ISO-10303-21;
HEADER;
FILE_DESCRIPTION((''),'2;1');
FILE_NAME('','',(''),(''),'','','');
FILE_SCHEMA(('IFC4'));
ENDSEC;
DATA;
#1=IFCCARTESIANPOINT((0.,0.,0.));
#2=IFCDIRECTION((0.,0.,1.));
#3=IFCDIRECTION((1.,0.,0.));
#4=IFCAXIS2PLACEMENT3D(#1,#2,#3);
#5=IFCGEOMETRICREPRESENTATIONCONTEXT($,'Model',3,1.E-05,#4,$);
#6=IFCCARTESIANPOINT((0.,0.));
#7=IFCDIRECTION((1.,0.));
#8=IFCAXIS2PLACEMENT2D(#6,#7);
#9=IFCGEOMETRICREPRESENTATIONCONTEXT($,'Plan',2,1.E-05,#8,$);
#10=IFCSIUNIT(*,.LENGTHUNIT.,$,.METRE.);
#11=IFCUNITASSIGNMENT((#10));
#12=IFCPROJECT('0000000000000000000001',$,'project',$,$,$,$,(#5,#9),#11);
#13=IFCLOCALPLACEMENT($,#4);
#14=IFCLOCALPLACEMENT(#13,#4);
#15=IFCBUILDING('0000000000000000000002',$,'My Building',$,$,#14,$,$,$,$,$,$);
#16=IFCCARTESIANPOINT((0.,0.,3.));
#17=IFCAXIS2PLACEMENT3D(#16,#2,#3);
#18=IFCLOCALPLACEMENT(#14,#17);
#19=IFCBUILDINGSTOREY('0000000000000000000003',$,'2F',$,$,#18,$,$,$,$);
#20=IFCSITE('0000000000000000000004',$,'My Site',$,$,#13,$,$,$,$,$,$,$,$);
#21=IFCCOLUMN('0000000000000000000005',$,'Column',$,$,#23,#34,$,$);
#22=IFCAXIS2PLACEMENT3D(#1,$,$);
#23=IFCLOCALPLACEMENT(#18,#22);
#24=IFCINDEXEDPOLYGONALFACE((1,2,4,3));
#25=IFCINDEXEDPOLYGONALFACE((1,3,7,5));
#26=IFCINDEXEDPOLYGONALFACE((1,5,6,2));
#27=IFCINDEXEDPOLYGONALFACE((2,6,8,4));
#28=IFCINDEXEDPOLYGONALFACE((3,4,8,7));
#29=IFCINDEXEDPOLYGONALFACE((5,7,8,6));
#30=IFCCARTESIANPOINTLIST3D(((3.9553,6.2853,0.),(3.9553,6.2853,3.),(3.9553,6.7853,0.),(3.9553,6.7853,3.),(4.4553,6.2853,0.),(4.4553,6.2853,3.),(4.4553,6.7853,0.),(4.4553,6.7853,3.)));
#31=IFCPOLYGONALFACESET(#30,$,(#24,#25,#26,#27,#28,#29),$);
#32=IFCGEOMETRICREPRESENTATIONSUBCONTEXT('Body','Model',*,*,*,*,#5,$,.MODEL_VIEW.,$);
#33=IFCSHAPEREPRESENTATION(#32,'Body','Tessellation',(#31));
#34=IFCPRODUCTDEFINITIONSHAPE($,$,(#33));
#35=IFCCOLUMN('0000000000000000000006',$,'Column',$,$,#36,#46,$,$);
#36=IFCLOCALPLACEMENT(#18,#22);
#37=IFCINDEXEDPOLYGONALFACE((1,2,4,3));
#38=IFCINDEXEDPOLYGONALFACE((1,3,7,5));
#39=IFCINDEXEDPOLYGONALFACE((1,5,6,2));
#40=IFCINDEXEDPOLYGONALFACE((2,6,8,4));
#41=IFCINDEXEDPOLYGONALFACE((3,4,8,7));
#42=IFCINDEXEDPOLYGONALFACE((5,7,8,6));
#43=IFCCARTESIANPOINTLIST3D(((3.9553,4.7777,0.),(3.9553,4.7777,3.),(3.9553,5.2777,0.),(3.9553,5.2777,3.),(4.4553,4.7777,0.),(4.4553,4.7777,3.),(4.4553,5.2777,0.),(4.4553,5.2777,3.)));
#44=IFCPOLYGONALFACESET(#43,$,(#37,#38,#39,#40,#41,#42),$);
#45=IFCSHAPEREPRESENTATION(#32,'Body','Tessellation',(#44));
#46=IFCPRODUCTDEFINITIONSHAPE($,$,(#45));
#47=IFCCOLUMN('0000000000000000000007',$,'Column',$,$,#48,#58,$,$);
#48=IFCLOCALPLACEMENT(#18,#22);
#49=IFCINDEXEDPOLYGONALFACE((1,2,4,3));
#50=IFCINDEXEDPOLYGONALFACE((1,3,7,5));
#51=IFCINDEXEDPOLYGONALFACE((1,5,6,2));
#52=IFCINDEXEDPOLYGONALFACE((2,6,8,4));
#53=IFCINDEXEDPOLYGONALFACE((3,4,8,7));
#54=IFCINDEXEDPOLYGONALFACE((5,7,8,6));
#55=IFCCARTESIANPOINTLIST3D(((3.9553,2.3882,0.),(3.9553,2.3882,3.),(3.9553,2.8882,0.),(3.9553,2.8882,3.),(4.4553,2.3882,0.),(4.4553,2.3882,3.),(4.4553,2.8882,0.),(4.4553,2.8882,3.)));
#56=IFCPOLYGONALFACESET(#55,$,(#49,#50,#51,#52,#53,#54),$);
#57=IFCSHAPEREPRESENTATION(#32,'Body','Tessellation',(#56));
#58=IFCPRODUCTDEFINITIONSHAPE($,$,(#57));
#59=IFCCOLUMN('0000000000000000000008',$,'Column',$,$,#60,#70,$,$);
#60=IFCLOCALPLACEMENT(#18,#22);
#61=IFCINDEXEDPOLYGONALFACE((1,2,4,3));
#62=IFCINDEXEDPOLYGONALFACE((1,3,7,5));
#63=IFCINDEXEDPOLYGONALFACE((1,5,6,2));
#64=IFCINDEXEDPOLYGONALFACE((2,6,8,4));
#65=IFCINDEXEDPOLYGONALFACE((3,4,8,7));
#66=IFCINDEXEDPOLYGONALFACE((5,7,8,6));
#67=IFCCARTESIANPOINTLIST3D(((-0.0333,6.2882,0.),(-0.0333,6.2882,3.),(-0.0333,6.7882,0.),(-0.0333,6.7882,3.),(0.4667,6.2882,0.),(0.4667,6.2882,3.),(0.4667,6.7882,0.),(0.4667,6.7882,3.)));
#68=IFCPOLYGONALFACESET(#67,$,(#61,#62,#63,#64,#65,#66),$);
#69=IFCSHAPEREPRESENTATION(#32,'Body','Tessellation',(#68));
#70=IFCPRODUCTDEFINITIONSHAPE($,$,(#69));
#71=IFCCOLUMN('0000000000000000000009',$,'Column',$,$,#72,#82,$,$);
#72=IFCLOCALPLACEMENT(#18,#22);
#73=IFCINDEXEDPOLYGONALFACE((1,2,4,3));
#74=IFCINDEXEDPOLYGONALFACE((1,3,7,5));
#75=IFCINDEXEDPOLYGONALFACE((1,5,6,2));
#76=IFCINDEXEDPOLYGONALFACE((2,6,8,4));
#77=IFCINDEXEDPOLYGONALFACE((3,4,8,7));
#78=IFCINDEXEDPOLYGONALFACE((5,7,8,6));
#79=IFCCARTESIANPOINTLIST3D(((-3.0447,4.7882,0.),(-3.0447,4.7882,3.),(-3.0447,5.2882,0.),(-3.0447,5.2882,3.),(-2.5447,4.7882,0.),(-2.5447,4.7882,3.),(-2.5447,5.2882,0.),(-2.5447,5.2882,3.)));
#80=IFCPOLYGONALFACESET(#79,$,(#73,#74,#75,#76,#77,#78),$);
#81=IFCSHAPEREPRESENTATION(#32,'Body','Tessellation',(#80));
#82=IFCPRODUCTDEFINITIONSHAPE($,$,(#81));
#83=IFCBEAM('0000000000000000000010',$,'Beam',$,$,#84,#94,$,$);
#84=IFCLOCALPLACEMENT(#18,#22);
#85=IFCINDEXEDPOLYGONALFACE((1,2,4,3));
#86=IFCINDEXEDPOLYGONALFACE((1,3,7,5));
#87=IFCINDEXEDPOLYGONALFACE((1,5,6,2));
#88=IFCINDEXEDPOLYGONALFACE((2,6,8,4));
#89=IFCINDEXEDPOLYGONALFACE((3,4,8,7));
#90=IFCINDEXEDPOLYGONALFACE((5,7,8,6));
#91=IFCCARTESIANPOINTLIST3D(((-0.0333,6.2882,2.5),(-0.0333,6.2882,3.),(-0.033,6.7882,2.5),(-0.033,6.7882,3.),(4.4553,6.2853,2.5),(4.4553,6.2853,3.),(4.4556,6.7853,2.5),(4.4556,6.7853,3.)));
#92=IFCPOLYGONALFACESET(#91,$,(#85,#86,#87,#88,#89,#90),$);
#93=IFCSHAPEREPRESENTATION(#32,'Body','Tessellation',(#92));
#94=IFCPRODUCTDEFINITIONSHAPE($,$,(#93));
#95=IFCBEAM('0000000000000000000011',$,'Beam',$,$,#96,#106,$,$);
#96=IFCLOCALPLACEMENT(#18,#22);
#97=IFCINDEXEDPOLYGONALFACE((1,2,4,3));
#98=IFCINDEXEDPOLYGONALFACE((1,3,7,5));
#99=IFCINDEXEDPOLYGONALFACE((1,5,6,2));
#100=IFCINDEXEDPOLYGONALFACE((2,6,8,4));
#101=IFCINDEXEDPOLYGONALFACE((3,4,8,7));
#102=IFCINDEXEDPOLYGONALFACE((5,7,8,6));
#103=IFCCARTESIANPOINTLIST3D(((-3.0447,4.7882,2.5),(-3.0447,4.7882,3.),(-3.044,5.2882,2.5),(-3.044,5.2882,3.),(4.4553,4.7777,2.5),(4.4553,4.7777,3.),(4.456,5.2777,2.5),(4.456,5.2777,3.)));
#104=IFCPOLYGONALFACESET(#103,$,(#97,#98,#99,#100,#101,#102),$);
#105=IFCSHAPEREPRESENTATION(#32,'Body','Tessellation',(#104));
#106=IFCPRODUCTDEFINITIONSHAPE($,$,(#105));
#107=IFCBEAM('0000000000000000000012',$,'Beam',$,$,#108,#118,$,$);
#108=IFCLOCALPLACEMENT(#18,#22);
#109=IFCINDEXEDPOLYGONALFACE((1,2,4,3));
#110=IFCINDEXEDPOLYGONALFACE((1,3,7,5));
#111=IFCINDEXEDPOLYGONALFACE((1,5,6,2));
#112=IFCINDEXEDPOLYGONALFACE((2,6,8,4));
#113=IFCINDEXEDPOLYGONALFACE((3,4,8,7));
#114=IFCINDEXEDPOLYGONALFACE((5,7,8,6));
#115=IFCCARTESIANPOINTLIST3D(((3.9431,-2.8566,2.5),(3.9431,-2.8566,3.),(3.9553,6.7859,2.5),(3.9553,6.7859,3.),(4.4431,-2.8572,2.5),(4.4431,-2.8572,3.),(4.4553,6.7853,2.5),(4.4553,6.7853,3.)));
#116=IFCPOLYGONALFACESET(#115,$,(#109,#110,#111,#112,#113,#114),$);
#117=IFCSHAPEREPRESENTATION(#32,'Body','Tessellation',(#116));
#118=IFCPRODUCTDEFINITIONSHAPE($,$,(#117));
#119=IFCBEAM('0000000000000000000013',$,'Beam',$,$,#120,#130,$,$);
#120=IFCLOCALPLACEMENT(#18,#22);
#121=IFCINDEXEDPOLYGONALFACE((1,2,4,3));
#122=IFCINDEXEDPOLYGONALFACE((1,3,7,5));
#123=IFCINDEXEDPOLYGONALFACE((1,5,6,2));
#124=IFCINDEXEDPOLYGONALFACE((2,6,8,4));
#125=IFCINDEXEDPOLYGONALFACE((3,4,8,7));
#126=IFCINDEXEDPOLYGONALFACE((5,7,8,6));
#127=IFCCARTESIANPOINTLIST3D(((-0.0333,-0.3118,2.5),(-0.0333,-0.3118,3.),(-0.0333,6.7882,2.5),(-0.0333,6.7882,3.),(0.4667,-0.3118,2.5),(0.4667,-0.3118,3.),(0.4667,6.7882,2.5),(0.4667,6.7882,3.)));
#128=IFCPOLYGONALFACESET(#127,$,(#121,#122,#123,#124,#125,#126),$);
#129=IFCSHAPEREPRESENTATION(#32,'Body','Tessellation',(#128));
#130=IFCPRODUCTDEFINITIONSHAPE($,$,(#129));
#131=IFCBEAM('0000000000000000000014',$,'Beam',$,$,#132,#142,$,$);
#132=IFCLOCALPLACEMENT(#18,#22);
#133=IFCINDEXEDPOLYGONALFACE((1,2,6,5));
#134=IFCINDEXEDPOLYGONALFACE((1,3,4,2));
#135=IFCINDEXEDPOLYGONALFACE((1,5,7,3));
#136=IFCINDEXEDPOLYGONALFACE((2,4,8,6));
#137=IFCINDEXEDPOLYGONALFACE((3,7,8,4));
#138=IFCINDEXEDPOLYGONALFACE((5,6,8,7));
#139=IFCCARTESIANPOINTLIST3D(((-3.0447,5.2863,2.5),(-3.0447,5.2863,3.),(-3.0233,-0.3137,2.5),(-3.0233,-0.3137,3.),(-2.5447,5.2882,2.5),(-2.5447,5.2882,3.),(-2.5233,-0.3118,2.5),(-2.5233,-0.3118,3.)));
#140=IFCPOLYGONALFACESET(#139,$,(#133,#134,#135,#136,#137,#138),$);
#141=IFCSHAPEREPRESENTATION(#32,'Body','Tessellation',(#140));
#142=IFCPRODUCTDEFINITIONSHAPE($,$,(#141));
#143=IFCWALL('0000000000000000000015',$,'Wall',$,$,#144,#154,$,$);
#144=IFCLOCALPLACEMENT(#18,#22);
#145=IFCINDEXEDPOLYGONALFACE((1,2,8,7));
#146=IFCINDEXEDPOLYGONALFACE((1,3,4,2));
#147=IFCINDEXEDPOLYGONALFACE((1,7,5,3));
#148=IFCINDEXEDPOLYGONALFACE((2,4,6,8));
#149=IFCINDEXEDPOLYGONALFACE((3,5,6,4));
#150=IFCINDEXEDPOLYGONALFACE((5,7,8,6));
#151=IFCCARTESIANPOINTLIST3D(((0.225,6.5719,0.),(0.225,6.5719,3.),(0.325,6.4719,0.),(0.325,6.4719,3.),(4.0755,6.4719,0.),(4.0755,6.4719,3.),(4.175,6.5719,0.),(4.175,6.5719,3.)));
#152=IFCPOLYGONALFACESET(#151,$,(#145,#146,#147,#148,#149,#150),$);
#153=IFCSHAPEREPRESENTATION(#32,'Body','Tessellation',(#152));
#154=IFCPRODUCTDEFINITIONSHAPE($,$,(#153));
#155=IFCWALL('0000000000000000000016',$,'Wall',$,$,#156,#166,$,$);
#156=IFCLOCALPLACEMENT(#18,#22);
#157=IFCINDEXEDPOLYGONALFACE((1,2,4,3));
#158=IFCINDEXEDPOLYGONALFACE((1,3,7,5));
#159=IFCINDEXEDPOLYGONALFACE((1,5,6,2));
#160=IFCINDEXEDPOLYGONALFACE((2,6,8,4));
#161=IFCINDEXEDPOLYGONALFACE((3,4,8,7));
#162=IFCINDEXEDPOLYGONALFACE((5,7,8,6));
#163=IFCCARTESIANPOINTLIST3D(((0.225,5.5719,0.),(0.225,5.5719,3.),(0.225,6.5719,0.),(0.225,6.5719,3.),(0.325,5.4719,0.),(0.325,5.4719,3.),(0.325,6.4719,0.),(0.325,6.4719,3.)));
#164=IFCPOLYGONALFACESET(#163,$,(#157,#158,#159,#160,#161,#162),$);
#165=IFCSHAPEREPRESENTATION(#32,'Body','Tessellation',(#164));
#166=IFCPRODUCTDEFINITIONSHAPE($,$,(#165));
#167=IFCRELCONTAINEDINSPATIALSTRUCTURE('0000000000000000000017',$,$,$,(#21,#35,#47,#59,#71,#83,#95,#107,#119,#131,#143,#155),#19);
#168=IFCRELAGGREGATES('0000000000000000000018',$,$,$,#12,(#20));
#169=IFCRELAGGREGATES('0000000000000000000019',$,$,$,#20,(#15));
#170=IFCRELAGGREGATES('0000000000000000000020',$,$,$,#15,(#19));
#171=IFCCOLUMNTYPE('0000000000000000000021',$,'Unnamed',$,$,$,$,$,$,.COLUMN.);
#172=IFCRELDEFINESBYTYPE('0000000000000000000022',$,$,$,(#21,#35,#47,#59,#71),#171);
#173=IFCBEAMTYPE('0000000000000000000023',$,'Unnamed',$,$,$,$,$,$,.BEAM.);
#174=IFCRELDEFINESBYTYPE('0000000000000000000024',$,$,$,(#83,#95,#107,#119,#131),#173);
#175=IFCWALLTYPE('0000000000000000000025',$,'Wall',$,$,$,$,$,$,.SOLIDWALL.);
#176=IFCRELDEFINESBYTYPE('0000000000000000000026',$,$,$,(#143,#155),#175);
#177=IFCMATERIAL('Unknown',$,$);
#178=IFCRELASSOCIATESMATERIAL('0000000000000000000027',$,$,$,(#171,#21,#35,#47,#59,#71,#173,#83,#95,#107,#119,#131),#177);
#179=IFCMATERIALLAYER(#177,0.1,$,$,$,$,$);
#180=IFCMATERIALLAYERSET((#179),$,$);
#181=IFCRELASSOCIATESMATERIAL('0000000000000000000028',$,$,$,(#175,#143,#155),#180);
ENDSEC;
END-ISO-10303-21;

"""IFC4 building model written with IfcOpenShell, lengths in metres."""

from ifc_helpers import new_model, si_unit, frame, origin_with_axes, origin_2d_with_axis, place, context, subcontext, project, spatial, line, indexed_curve, rectangle, outline, extrude, material, layer, layer_set, layer_usage, material_profile, profile_set, profile_usage, type_object, element, save


model = new_model("IFC4")

# Units and contexts
model_context = context("Model", 3, precision=1e-05, world=origin_with_axes())
plan_context = context("Plan", 2, precision=1e-05, world=origin_2d_with_axis())
body_context_1 = subcontext(model_context, "Body", "Model", "MODEL_VIEW")
ifc_project = project(units=[si_unit("LENGTHUNIT", "METRE")], contexts=[model_context, plan_context])

# Site, building, storey
site_placement = place(None, origin_with_axes())
site = spatial("IfcSite", under=ifc_project, at=site_placement, Name="My Site")
building_placement = place(site_placement, origin_with_axes())
building = spatial("IfcBuilding", under=site, at=building_placement, Name="My Building")
storey_placement = place(building_placement, frame((0.0, 0.0, 3.0), z_axis=(0.0, 0.0, 1.0), x_axis=(1.0, 0.0, 0.0)))
storey = spatial("IfcBuildingStorey", under=building, at=storey_placement, Name="2F")

# Columns
ifc_material = material(Name="Unknown")
ifc_material_profile_1 = material_profile(ifc_material, rectangle(XDim=0.5, YDim=0.5))
ifc_profile_set_1 = profile_set([ifc_material_profile_1])
ifc_profile_usage_1 = profile_usage(ifc_profile_set_1, cardinal=5)
column_type = type_object("IfcColumnType", Name="Unnamed", PredefinedType="COLUMN", material=ifc_profile_set_1)
column_1_placement = place(storey_placement, frame((4.2053, 6.5353, 0.0), z_axis=(0.0, 0.0, 1.0), x_axis=(1.0, 0.0, 0.0)))
element("IfcColumn", 1, at=column_1_placement, inside=storey, type_object=column_type, material=ifc_profile_usage_1, Name="Column", context=body_context_1, shape_type="SweptSolid", body=[
    extrude(rectangle(XDim=0.5, YDim=0.5), origin_with_axes(), (0.0, 0.0, 1.0), 3.0),
])
ifc_profile_usage_2 = profile_usage(ifc_profile_set_1, cardinal=5)
column_2_placement = place(storey_placement, frame((4.2053, 5.0277, 0.0), z_axis=(0.0, 0.0, 1.0), x_axis=(1.0, 0.0, 0.0)))
element("IfcColumn", 2, at=column_2_placement, inside=storey, type_object=column_type, material=ifc_profile_usage_2, Name="Column", context=body_context_1, shape_type="SweptSolid", body=[
    extrude(rectangle(XDim=0.5, YDim=0.5), origin_with_axes(), (0.0, 0.0, 1.0), 3.0),
])
ifc_profile_usage_3 = profile_usage(ifc_profile_set_1, cardinal=5)
column_3_placement = place(storey_placement, frame((4.2053, 2.6382, 0.0), z_axis=(0.0, 0.0, 1.0), x_axis=(1.0, 0.0, 0.0)))
element("IfcColumn", 3, at=column_3_placement, inside=storey, type_object=column_type, material=ifc_profile_usage_3, Name="Column", context=body_context_1, shape_type="SweptSolid", body=[
    extrude(rectangle(XDim=0.5, YDim=0.5), origin_with_axes(), (0.0, 0.0, 1.0), 3.0),
])
ifc_profile_usage_4 = profile_usage(ifc_profile_set_1, cardinal=5)
column_4_placement = place(storey_placement, frame((0.2167, 6.5382, 0.0), z_axis=(0.0, 0.0, 1.0), x_axis=(1.0, 0.0, 0.0)))
element("IfcColumn", 4, at=column_4_placement, inside=storey, type_object=column_type, material=ifc_profile_usage_4, Name="Column", context=body_context_1, shape_type="SweptSolid", body=[
    extrude(rectangle(XDim=0.5, YDim=0.5), origin_with_axes(), (0.0, 0.0, 1.0), 3.0),
])
ifc_profile_usage_5 = profile_usage(ifc_profile_set_1, cardinal=5)
column_5_placement = place(storey_placement, frame((-2.7947, 5.0382, 0.0), z_axis=(0.0, 0.0, 1.0), x_axis=(1.0, 0.0, 0.0)))
element("IfcColumn", 5, at=column_5_placement, inside=storey, type_object=column_type, material=ifc_profile_usage_5, Name="Column", context=body_context_1, shape_type="SweptSolid", body=[
    extrude(rectangle(XDim=0.5, YDim=0.5), origin_with_axes(), (0.0, 0.0, 1.0), 3.0),
])

# Beams
ifc_material_profile_2 = material_profile(ifc_material, rectangle(XDim=0.5, YDim=0.5))
ifc_profile_set_2 = profile_set([ifc_material_profile_2])
ifc_profile_usage_6 = profile_usage(ifc_profile_set_2, cardinal=7)
beam_type = type_object("IfcBeamType", Name="Unnamed", PredefinedType="BEAM", material=ifc_profile_set_2)
beam_1_placement = place(storey_placement, frame((4.4553, 6.2853, 3.0), z_axis=(-1.0, 0.000651, 0.0), x_axis=(-0.000651, -1.0, 0.0)))
element("IfcBeam", 6, at=beam_1_placement, inside=storey, type_object=beam_type, material=ifc_profile_usage_6, Name="Beam", context=body_context_1, shape_type="SweptSolid", body=[
    extrude(rectangle(XDim=0.5, YDim=0.5), frame((-0.25, -0.25, 0.0), z_axis=(0.0, 0.0, 1.0), x_axis=(1.0, 0.0, 0.0)), (0.0, 0.0, 1.0), 4.4886),
])
ifc_profile_usage_7 = profile_usage(ifc_profile_set_2, cardinal=7)
beam_2_placement = place(storey_placement, frame((4.4553, 4.7777, 3.0), z_axis=(-0.999999, 0.001406, 0.0), x_axis=(-0.001406, -0.999999, 0.0)))
element("IfcBeam", 7, at=beam_2_placement, inside=storey, type_object=beam_type, material=ifc_profile_usage_7, Name="Beam", context=body_context_1, shape_type="SweptSolid", body=[
    extrude(rectangle(XDim=0.5, YDim=0.5), frame((-0.25, -0.25, 0.0), z_axis=(0.0, 0.0, 1.0), x_axis=(1.0, 0.0, 0.0)), (0.0, 0.0, 1.0), 7.5),
])
ifc_profile_usage_8 = profile_usage(ifc_profile_set_2, cardinal=7)
beam_3_placement = place(storey_placement, frame((4.4553, 6.7853, 3.0), z_axis=(-0.001263, -0.999999, 0.0), x_axis=(0.999999, -0.001263, 0.0)))
element("IfcBeam", 8, at=beam_3_placement, inside=storey, type_object=beam_type, material=ifc_profile_usage_8, Name="Beam", context=body_context_1, shape_type="SweptSolid", body=[
    extrude(rectangle(XDim=0.5, YDim=0.5), frame((-0.25, -0.25, 0.0), z_axis=(0.0, 0.0, 1.0), x_axis=(1.0, 0.0, 0.0)), (0.0, 0.0, 1.0), 9.6425),
])
ifc_profile_usage_9 = profile_usage(ifc_profile_set_2, cardinal=7)
beam_4_placement = place(storey_placement, frame((0.4667, 6.7882, 3.0), z_axis=(0.0, -1.0, 0.0), x_axis=(1.0, 0.0, 0.0)))
element("IfcBeam", 9, at=beam_4_placement, inside=storey, type_object=beam_type, material=ifc_profile_usage_9, Name="Beam", context=body_context_1, shape_type="SweptSolid", body=[
    extrude(rectangle(XDim=0.5, YDim=0.5), frame((-0.25, -0.25, 0.0), z_axis=(0.0, 0.0, 1.0), x_axis=(1.0, 0.0, 0.0)), (0.0, 0.0, 1.0), 7.1),
])
ifc_profile_usage_10 = profile_usage(ifc_profile_set_2, cardinal=7)
beam_5_placement = place(storey_placement, frame((-2.5447, 5.2882, 3.0), z_axis=(0.003815, -0.999993, 0.0), x_axis=(0.999993, 0.003815, 0.0)))
element("IfcBeam", 10, at=beam_5_placement, inside=storey, type_object=beam_type, material=ifc_profile_usage_10, Name="Beam", context=body_context_1, shape_type="SweptSolid", body=[
    extrude(rectangle(XDim=0.5, YDim=0.5), frame((-0.25, -0.25, 0.0), z_axis=(0.0, 0.0, 1.0), x_axis=(1.0, 0.0, 0.0)), (0.0, 0.0, 1.0), 5.6),
])

# Walls
ifc_layer = layer(ifc_material, 0.1)
ifc_layer_set = layer_set([ifc_layer])
ifc_layer_usage_1 = layer_usage(ifc_layer_set, "AXIS2", "POSITIVE", 0.0)
wall_type = type_object("IfcWallType", Name="Wall", PredefinedType="SOLIDWALL", material=ifc_layer_set)
wall_1_placement = place(storey_placement, frame((4.175, 6.5719, 0.0), z_axis=(0.0, 0.0, 1.0), x_axis=(-1.0, 0.0, 0.0)))
element("IfcWall", 11, at=wall_1_placement, inside=storey, type_object=wall_type, material=ifc_layer_usage_1, Name="Wall", context=body_context_1, shape_type="SweptSolid", body=[
    extrude(outline(indexed_curve([(0.0, 0.0), (0.0995, 0.1), (3.85, 0.1), (3.95, 0.0)], segments=[line(1, 2, 3, 4, 1)])), origin_with_axes(), (0.0, 0.0, 1.0), 3.0),
])
ifc_layer_usage_2 = layer_usage(ifc_layer_set, "AXIS2", "POSITIVE", 0.0)
wall_2_placement = place(storey_placement, frame((0.225, 6.5719, 0.0), z_axis=(0.0, 0.0, 1.0), x_axis=(0.0, -1.0, 0.0)))
element("IfcWall", 12, at=wall_2_placement, inside=storey, type_object=wall_type, material=ifc_layer_usage_2, Name="Wall", context=body_context_1, shape_type="SweptSolid", body=[
    extrude(outline(indexed_curve([(0.0, 0.0), (0.1, 0.1), (1.1, 0.1), (1.0, 0.0)], segments=[line(1, 2, 3, 4, 1)])), origin_with_axes(), (0.0, 0.0, 1.0), 3.0),
])

save(model, "model.ifc")
